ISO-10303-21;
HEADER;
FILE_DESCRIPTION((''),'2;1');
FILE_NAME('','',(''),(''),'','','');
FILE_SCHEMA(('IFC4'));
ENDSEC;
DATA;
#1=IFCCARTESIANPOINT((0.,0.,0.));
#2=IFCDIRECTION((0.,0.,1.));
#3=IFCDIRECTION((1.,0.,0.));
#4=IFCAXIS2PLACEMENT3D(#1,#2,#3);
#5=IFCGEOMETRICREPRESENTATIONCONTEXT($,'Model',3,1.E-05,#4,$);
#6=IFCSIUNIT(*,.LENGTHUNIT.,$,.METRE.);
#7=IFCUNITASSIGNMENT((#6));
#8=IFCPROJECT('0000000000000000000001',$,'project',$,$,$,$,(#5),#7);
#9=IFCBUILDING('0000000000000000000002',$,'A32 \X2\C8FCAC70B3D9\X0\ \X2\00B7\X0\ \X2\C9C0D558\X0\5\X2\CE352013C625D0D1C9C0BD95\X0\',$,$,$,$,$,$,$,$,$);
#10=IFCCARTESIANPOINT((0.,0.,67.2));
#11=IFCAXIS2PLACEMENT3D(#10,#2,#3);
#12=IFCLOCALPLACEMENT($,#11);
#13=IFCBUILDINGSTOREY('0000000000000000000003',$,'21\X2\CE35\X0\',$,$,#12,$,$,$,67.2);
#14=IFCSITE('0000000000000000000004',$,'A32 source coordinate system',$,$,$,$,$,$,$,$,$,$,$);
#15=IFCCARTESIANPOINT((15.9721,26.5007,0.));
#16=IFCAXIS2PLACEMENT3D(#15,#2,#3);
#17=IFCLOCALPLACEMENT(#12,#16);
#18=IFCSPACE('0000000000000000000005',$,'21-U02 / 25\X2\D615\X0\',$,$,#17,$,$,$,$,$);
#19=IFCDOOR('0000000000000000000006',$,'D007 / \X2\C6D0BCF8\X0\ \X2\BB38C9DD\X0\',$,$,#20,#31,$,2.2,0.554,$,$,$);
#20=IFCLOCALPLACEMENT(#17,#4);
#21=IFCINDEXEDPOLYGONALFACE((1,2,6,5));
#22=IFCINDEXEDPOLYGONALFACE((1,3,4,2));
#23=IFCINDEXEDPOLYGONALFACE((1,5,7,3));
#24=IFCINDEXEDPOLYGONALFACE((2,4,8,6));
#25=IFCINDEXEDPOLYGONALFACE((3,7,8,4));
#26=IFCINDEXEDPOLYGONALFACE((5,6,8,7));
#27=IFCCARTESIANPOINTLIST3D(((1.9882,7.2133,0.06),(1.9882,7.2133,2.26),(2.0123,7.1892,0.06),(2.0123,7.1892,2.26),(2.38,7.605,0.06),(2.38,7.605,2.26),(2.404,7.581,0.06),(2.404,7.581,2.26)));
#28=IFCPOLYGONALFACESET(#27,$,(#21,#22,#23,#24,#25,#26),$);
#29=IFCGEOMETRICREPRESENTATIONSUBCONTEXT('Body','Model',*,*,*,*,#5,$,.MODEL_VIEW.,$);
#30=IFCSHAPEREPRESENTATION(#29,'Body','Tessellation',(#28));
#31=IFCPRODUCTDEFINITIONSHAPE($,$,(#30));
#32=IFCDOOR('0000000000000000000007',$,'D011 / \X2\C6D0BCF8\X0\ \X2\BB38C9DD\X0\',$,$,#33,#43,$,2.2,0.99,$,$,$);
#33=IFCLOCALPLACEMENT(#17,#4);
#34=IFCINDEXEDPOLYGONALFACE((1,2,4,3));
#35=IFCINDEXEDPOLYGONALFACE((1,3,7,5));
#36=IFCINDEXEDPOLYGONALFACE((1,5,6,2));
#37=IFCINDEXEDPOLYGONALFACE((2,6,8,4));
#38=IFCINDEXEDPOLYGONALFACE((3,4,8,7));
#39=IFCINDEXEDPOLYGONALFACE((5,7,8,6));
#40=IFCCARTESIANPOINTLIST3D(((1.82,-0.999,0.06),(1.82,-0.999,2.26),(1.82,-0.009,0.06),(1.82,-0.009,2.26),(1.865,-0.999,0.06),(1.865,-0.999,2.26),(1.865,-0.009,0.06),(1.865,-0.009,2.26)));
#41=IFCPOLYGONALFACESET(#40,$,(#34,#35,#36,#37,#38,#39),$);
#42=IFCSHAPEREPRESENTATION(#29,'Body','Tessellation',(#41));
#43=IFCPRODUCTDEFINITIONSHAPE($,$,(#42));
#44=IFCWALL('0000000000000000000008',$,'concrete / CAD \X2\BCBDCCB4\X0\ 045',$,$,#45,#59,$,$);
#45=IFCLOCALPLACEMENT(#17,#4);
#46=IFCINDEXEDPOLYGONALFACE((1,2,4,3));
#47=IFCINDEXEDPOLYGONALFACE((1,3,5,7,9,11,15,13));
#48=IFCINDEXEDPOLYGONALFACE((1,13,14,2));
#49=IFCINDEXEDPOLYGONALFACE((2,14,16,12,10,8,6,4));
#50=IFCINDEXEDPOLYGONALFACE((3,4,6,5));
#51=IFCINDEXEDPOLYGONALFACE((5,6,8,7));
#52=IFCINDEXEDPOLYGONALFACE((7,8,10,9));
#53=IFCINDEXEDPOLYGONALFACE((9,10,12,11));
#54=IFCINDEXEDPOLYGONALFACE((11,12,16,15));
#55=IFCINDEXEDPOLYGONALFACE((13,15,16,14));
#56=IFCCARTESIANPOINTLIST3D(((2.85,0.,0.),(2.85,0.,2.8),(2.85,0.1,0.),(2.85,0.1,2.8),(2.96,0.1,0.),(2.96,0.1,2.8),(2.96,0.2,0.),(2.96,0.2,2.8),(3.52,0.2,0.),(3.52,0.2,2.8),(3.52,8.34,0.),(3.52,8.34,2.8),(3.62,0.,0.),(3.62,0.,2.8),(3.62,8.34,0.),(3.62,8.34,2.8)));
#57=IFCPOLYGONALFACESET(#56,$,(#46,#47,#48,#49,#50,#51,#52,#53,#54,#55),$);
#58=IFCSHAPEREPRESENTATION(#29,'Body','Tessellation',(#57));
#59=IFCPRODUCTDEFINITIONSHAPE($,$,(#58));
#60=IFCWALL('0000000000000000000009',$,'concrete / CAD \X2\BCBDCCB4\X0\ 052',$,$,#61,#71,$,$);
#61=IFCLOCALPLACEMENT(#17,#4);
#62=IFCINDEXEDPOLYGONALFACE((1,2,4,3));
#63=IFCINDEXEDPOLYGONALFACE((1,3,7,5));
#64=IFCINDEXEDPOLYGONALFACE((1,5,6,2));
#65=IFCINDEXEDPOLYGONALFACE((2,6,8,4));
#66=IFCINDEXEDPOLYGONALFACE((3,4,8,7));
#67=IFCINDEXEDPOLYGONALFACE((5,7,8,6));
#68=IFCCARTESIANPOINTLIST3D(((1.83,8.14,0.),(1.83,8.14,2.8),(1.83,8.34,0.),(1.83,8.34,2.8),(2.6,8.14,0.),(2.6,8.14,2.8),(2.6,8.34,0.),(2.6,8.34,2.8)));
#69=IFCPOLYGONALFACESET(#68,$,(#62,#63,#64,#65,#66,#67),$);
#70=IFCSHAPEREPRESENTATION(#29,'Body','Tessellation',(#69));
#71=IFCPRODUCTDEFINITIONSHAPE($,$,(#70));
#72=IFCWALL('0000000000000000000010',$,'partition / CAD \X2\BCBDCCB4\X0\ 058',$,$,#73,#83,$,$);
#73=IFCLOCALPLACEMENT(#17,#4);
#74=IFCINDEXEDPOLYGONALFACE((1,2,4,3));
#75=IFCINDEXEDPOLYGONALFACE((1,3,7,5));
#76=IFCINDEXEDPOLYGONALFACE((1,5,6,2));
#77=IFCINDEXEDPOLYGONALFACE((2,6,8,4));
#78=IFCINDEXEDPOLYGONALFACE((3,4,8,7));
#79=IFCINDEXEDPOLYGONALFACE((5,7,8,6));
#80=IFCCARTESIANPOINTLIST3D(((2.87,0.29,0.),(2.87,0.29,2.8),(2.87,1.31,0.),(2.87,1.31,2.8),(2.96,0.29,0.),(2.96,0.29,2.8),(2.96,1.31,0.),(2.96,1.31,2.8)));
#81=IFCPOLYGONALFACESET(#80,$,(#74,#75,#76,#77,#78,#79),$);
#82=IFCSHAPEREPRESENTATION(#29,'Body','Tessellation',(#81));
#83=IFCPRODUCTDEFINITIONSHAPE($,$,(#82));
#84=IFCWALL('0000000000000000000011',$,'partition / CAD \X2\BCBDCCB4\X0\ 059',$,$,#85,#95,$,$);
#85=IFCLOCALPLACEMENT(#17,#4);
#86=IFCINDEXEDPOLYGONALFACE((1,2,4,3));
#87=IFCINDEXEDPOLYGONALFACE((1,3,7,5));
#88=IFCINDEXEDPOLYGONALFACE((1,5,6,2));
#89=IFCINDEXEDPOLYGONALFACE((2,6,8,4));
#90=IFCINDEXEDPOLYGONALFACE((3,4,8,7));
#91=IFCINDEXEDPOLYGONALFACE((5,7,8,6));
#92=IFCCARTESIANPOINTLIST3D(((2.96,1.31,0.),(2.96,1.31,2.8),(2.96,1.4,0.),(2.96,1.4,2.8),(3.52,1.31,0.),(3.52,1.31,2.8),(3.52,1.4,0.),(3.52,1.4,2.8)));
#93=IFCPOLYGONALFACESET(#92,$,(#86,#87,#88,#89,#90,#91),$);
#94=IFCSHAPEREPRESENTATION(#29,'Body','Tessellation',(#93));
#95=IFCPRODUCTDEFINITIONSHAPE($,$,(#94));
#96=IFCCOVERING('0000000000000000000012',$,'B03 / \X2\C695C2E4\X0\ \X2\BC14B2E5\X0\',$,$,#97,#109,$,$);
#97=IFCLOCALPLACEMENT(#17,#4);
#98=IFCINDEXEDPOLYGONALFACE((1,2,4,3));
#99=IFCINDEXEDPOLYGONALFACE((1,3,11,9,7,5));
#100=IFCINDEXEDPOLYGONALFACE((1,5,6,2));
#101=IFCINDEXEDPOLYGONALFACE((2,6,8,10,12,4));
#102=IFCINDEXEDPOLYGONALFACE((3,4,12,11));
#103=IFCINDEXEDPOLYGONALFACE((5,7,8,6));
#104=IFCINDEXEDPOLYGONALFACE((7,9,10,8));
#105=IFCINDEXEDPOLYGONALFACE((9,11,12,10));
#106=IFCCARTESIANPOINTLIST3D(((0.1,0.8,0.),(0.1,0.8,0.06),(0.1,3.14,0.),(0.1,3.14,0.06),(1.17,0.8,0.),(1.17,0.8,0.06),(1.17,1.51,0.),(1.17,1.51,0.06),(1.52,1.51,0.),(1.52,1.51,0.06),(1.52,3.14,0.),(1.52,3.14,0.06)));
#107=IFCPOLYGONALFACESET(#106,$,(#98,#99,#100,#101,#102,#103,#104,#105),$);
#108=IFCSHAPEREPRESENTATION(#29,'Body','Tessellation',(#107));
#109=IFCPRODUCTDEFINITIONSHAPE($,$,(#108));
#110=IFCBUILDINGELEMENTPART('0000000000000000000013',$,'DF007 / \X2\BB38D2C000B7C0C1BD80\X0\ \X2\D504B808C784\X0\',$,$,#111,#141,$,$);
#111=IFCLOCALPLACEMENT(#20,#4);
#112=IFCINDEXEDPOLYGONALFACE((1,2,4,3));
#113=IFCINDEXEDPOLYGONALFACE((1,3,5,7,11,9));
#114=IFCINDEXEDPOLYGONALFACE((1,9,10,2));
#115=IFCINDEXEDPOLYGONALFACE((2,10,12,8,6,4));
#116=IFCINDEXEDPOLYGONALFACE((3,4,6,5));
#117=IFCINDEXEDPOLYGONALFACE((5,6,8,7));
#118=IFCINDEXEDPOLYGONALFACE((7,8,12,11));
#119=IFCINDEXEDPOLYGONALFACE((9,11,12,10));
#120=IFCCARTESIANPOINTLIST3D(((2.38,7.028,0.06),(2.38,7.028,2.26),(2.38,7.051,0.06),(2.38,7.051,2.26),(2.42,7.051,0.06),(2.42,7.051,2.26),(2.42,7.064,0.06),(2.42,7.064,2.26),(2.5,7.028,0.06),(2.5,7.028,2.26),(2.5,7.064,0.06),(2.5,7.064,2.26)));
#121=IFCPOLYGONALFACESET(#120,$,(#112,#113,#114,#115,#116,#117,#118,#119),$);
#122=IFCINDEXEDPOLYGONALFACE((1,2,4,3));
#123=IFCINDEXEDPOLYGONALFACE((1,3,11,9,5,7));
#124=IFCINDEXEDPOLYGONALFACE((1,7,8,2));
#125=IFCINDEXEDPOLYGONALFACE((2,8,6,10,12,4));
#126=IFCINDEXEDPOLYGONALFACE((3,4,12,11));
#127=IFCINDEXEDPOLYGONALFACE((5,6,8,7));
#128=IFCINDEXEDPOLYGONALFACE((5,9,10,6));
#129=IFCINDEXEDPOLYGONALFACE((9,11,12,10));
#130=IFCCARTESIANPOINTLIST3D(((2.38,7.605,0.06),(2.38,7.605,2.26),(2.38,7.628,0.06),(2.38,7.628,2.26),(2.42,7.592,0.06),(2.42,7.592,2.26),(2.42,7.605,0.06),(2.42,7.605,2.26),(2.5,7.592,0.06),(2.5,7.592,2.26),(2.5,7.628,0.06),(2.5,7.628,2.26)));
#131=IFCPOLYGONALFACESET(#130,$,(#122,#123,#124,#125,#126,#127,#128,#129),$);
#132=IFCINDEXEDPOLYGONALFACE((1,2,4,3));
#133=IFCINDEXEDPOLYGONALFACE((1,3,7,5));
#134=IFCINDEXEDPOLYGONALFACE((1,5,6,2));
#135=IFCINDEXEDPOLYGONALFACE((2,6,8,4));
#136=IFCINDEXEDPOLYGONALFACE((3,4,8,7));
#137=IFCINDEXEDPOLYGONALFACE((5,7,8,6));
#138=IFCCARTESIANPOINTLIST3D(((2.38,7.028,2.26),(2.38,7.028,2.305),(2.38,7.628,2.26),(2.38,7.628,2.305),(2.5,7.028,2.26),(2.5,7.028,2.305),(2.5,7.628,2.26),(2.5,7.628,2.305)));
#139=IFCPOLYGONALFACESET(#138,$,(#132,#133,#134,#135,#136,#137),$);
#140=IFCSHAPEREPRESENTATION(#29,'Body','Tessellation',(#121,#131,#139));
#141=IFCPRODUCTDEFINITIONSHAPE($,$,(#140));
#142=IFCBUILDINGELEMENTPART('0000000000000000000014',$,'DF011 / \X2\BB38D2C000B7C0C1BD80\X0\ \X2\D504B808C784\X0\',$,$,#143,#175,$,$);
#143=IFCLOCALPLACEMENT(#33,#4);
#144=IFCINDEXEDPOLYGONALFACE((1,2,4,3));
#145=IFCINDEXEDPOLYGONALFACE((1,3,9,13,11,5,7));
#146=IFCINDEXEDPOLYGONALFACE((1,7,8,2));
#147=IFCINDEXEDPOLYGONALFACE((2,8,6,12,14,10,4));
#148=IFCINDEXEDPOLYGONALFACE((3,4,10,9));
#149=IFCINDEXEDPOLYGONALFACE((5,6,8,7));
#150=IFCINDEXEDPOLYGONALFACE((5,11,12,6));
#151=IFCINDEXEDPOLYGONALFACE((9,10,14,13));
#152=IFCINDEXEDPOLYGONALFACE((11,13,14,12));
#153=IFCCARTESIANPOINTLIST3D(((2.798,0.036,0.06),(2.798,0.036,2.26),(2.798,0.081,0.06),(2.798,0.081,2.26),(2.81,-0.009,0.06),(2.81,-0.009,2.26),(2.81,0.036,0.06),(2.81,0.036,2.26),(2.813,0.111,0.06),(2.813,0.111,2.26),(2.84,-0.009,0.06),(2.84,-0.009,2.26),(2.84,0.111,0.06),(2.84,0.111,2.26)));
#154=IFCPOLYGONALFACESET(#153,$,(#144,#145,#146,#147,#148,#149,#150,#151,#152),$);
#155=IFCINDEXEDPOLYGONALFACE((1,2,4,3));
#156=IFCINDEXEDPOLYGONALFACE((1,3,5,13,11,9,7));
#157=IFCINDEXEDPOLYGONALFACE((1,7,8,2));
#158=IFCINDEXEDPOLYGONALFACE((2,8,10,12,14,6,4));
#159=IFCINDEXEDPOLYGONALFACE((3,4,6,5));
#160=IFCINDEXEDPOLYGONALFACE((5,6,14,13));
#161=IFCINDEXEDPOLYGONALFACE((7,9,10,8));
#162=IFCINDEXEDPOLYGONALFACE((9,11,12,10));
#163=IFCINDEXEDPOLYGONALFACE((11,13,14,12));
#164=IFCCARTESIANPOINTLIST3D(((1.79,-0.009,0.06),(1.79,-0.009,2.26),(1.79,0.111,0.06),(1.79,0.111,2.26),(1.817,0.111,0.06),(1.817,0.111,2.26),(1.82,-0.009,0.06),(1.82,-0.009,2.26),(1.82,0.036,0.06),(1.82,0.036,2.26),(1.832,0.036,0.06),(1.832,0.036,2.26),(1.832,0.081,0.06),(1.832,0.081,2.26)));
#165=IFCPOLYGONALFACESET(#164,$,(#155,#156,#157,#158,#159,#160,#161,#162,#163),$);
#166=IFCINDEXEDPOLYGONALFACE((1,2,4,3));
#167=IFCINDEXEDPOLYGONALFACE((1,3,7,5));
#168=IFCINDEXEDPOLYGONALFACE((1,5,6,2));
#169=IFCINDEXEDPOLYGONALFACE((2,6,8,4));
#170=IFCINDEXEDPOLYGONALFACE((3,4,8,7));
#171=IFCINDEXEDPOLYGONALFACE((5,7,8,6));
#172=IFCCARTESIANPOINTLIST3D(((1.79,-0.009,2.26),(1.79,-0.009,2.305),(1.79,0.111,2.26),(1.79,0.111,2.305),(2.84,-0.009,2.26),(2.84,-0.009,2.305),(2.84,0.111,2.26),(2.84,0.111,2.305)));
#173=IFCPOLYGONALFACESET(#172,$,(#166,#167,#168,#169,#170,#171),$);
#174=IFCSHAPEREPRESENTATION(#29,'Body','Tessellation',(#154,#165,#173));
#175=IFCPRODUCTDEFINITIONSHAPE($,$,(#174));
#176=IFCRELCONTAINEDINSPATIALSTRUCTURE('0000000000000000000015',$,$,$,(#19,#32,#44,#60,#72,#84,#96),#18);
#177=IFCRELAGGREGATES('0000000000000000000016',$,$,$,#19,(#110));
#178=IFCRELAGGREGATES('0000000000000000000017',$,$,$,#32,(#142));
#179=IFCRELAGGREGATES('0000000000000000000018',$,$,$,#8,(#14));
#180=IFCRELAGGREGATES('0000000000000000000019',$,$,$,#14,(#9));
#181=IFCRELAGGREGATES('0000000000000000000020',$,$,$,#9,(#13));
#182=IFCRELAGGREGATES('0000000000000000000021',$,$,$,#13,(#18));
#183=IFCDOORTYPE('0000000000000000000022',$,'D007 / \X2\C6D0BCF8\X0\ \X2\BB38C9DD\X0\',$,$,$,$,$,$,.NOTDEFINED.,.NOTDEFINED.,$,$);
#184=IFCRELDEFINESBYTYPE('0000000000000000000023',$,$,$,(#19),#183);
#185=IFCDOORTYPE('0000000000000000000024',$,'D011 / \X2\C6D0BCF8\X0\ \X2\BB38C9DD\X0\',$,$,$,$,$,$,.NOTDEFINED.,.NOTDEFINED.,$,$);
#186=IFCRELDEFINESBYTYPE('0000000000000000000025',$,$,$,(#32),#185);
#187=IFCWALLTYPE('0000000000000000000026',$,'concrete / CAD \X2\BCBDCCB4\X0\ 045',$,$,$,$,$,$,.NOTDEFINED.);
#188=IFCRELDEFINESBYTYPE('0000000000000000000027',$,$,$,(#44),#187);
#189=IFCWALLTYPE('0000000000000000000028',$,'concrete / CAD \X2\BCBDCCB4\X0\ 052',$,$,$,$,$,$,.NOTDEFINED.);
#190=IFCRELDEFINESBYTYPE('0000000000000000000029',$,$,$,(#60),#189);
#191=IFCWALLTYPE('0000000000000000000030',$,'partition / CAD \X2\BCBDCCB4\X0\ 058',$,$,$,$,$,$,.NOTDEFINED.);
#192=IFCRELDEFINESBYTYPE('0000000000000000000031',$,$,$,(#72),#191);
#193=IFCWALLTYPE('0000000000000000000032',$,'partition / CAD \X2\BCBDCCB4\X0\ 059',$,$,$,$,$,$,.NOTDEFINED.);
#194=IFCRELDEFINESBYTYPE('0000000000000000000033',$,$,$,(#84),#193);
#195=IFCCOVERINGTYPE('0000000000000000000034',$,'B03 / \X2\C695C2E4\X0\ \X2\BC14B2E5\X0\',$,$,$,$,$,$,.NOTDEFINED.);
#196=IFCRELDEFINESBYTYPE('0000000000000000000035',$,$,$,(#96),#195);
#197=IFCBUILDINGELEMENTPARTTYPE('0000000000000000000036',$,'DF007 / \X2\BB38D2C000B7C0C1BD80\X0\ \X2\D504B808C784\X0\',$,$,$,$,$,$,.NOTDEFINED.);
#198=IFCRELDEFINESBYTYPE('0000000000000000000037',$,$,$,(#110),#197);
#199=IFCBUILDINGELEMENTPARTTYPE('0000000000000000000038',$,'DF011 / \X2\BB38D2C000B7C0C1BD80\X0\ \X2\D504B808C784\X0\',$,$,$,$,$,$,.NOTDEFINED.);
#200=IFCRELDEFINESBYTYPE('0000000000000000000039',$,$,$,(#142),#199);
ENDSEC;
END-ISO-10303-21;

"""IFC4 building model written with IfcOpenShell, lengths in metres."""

from ifc_helpers import new_model, si_unit, frame, origin, origin_with_axes, place, context, subcontext, project, spatial, polyline, outline, extrude, source, transform, mapped, type_object, type_shapes, element, aggregate, save


model = new_model("IFC4")

# Units and contexts
model_context = context("Model", 3, precision=1e-05, world=origin_with_axes())
body_context = subcontext(model_context, "Body", "Model", "MODEL_VIEW")
ifc_project = project(units=[si_unit("LENGTHUNIT", "METRE")], contexts=[model_context])

# Site, building, storey, space
storey_placement = place(None, frame((0.0, 0.0, 67.2), z_axis=(0.0, 0.0, 1.0), x_axis=(1.0, 0.0, 0.0)))
space_placement = place(storey_placement, frame((15.9721, 26.5007, 0.0), z_axis=(0.0, 0.0, 1.0), x_axis=(1.0, 0.0, 0.0)))
site = spatial("IfcSite", under=ifc_project, Name="A32 source coordinate system")
building = spatial("IfcBuilding", under=site, Name="A32 주거동 · 지하5층–옥탑지붕")
storey = spatial("IfcBuildingStorey", under=building, at=storey_placement, Name="21층", Elevation=67.2)
space = spatial("IfcSpace", under=storey, at=space_placement, Name="21-U02 / 25형")

# Doors
door_type_1 = type_object("IfcDoorType", Name="D007 / 원본 문짝", OperationType="NOTDEFINED", PredefinedType="NOTDEFINED")
shared_shape_1 = source(origin(), body_context, "Body", "SweptSolid", [
    extrude(outline(polyline([(2.0123, 7.1892), (1.9882, 7.2133), (2.38, 7.605), (2.404, 7.581), (2.0123, 7.1892)])), frame((0.0, 0.0, 0.06)), (0.0, 0.0, 1.0), 2.2),
])
type_shapes(door_type_1, [shared_shape_1])
door_1_placement = place(space_placement, origin_with_axes())
door_1 = element("IfcDoor", 1, at=door_1_placement, inside=space, type_object=door_type_1, Name="D007 / 원본 문짝", OverallHeight=2.2, OverallWidth=0.554, context=body_context, shape_type="MappedRepresentation", body=[
    mapped(shared_shape_1, transform((0.0, 0.0, 0.0), scale=1.0)),
])
door_type_2 = type_object("IfcDoorType", Name="D011 / 원본 문짝", OperationType="NOTDEFINED", PredefinedType="NOTDEFINED")
shared_shape_2 = source(origin(), body_context, "Body", "SweptSolid", [
    extrude(outline(polyline([(1.865, -0.999), (1.82, -0.999), (1.82, -0.009), (1.865, -0.009), (1.865, -0.999)])), frame((0.0, 0.0, 0.06)), (0.0, 0.0, 1.0), 2.2),
])
type_shapes(door_type_2, [shared_shape_2])
door_2_placement = place(space_placement, origin_with_axes())
door_2 = element("IfcDoor", 2, at=door_2_placement, inside=space, type_object=door_type_2, Name="D011 / 원본 문짝", OverallHeight=2.2, OverallWidth=0.99, context=body_context, shape_type="MappedRepresentation", body=[
    mapped(shared_shape_2, transform((0.0, 0.0, 0.0), scale=1.0)),
])

# Walls
wall_type_1 = type_object("IfcWallType", Name="concrete / CAD 벽체 045", PredefinedType="NOTDEFINED")
shared_shape_3 = source(origin(), body_context, "Body", "SweptSolid", [
    extrude(outline(polyline([(2.96, 0.1), (2.96, 0.2), (3.52, 0.2), (3.52, 8.34), (3.72, 8.34), (3.72, 8.34), (3.62, 8.34), (3.62, 0.0), (2.85, 0.0), (2.85, 0.1), (2.96, 0.1)])), origin(), (0.0, 0.0, 1.0), 2.8),
])
type_shapes(wall_type_1, [shared_shape_3])
wall_1_placement = place(space_placement, origin_with_axes())
element("IfcWall", 3, at=wall_1_placement, inside=space, type_object=wall_type_1, Name="concrete / CAD 벽체 045", context=body_context, shape_type="MappedRepresentation", body=[
    mapped(shared_shape_3, transform((0.0, 0.0, 0.0), scale=1.0)),
])
wall_type_2 = type_object("IfcWallType", Name="concrete / CAD 벽체 052", PredefinedType="NOTDEFINED")
shared_shape_4 = source(origin(), body_context, "Body", "SweptSolid", [
    extrude(outline(polyline([(2.6, 8.14), (1.83, 8.14), (1.83, 8.34), (2.6, 8.34), (2.6, 8.14)])), origin(), (0.0, 0.0, 1.0), 2.8),
])
type_shapes(wall_type_2, [shared_shape_4])
wall_2_placement = place(space_placement, origin_with_axes())
element("IfcWall", 4, at=wall_2_placement, inside=space, type_object=wall_type_2, Name="concrete / CAD 벽체 052", context=body_context, shape_type="MappedRepresentation", body=[
    mapped(shared_shape_4, transform((0.0, 0.0, 0.0), scale=1.0)),
])
wall_type_3 = type_object("IfcWallType", Name="partition / CAD 벽체 058", PredefinedType="NOTDEFINED")
shared_shape_5 = source(origin(), body_context, "Body", "SweptSolid", [
    extrude(outline(polyline([(2.96, 1.31), (2.96, 0.29), (2.87, 0.29), (2.87, 1.31), (2.96, 1.31)])), origin(), (0.0, 0.0, 1.0), 2.8),
])
type_shapes(wall_type_3, [shared_shape_5])
wall_3_placement = place(space_placement, origin_with_axes())
element("IfcWall", 5, at=wall_3_placement, inside=space, type_object=wall_type_3, Name="partition / CAD 벽체 058", context=body_context, shape_type="MappedRepresentation", body=[
    mapped(shared_shape_5, transform((0.0, 0.0, 0.0), scale=1.0)),
])
wall_type_4 = type_object("IfcWallType", Name="partition / CAD 벽체 059", PredefinedType="NOTDEFINED")
shared_shape_6 = source(origin(), body_context, "Body", "SweptSolid", [
    extrude(outline(polyline([(3.52, 1.31), (2.96, 1.31), (2.96, 1.4), (3.52, 1.4), (3.52, 1.31)])), origin(), (0.0, 0.0, 1.0), 2.8),
])
type_shapes(wall_type_4, [shared_shape_6])
wall_4_placement = place(space_placement, origin_with_axes())
element("IfcWall", 6, at=wall_4_placement, inside=space, type_object=wall_type_4, Name="partition / CAD 벽체 059", context=body_context, shape_type="MappedRepresentation", body=[
    mapped(shared_shape_6, transform((0.0, 0.0, 0.0), scale=1.0)),
])

# Covering
covering_type_1 = type_object("IfcCoveringType", Name="B03 / 욕실 바닥", PredefinedType="NOTDEFINED")
shared_shape_7 = source(origin(), body_context, "Body", "SweptSolid", [
    extrude(outline(polyline([(1.17, 1.51), (1.17, 0.8), (0.1, 0.8), (0.1, 3.14), (1.52, 3.14), (1.52, 1.51), (1.17, 1.51)])), origin(), (0.0, 0.0, 1.0), 0.06),
])
type_shapes(covering_type_1, [shared_shape_7])
covering_1_placement = place(space_placement, origin_with_axes())
element("IfcCovering", 7, at=covering_1_placement, inside=space, type_object=covering_type_1, Name="B03 / 욕실 바닥", context=body_context, shape_type="MappedRepresentation", body=[
    mapped(shared_shape_7, transform((0.0, 0.0, 0.0), scale=1.0)),
])

# Building element parts
building_element_part_type_1 = type_object("IfcBuildingElementPartType", Name="DF007 / 문틀·상부 프레임", PredefinedType="NOTDEFINED")
shared_shape_8 = source(origin(), body_context, "Body", "SweptSolid", [
    extrude(outline(polyline([(2.38, 7.028), (2.38, 7.051), (2.42, 7.051), (2.42, 7.064), (2.5, 7.064), (2.5, 7.028), (2.38, 7.028)])), frame((0.0, 0.0, 0.06)), (0.0, 0.0, 1.0), 2.2),
    extrude(outline(polyline([(2.5, 7.592), (2.42, 7.592), (2.42, 7.605), (2.38, 7.605), (2.38, 7.628), (2.5, 7.628), (2.5, 7.592)])), frame((0.0, 0.0, 0.06)), (0.0, 0.0, 1.0), 2.2),
    extrude(outline(polyline([(2.38, 7.028), (2.38, 7.628), (2.5, 7.628), (2.5, 7.028), (2.38, 7.028)])), frame((0.0, 0.0, 2.26)), (0.0, 0.0, 1.0), 0.045),
])
type_shapes(building_element_part_type_1, [shared_shape_8])
building_element_part_1_placement = place(door_1_placement, origin_with_axes())
building_element_part_1 = element("IfcBuildingElementPart", 8, at=building_element_part_1_placement, type_object=building_element_part_type_1, Name="DF007 / 문틀·상부 프레임", context=body_context, shape_type="MappedRepresentation", body=[
    mapped(shared_shape_8, transform((0.0, 0.0, 0.0), scale=1.0)),
])
aggregate(door_1, [building_element_part_1])
building_element_part_type_2 = type_object("IfcBuildingElementPartType", Name="DF011 / 문틀·상부 프레임", PredefinedType="NOTDEFINED")
shared_shape_9 = source(origin(), body_context, "Body", "SweptSolid", [
    extrude(outline(polyline([(2.81, -0.009), (2.81, 0.036), (2.798, 0.036), (2.798, 0.081), (2.813, 0.111), (2.84, 0.111), (2.84, -0.009), (2.81, -0.009)])), frame((0.0, 0.0, 0.06)), (0.0, 0.0, 1.0), 2.2),
    extrude(outline(polyline([(1.79, 0.111), (1.817, 0.111), (1.832, 0.081), (1.832, 0.036), (1.82, 0.036), (1.82, -0.009), (1.79, -0.009), (1.79, 0.111)])), frame((0.0, 0.0, 0.06)), (0.0, 0.0, 1.0), 2.2),
    extrude(outline(polyline([(1.79, -0.009), (1.79, 0.111), (2.84, 0.111), (2.84, -0.009), (1.79, -0.009)])), frame((0.0, 0.0, 2.26)), (0.0, 0.0, 1.0), 0.045),
])
type_shapes(building_element_part_type_2, [shared_shape_9])
building_element_part_2_placement = place(door_2_placement, origin_with_axes())
building_element_part_2 = element("IfcBuildingElementPart", 9, at=building_element_part_2_placement, type_object=building_element_part_type_2, Name="DF011 / 문틀·상부 프레임", context=body_context, shape_type="MappedRepresentation", body=[
    mapped(shared_shape_9, transform((0.0, 0.0, 0.0), scale=1.0)),
])
aggregate(door_2, [building_element_part_2])

save(model, "model.ifc")
